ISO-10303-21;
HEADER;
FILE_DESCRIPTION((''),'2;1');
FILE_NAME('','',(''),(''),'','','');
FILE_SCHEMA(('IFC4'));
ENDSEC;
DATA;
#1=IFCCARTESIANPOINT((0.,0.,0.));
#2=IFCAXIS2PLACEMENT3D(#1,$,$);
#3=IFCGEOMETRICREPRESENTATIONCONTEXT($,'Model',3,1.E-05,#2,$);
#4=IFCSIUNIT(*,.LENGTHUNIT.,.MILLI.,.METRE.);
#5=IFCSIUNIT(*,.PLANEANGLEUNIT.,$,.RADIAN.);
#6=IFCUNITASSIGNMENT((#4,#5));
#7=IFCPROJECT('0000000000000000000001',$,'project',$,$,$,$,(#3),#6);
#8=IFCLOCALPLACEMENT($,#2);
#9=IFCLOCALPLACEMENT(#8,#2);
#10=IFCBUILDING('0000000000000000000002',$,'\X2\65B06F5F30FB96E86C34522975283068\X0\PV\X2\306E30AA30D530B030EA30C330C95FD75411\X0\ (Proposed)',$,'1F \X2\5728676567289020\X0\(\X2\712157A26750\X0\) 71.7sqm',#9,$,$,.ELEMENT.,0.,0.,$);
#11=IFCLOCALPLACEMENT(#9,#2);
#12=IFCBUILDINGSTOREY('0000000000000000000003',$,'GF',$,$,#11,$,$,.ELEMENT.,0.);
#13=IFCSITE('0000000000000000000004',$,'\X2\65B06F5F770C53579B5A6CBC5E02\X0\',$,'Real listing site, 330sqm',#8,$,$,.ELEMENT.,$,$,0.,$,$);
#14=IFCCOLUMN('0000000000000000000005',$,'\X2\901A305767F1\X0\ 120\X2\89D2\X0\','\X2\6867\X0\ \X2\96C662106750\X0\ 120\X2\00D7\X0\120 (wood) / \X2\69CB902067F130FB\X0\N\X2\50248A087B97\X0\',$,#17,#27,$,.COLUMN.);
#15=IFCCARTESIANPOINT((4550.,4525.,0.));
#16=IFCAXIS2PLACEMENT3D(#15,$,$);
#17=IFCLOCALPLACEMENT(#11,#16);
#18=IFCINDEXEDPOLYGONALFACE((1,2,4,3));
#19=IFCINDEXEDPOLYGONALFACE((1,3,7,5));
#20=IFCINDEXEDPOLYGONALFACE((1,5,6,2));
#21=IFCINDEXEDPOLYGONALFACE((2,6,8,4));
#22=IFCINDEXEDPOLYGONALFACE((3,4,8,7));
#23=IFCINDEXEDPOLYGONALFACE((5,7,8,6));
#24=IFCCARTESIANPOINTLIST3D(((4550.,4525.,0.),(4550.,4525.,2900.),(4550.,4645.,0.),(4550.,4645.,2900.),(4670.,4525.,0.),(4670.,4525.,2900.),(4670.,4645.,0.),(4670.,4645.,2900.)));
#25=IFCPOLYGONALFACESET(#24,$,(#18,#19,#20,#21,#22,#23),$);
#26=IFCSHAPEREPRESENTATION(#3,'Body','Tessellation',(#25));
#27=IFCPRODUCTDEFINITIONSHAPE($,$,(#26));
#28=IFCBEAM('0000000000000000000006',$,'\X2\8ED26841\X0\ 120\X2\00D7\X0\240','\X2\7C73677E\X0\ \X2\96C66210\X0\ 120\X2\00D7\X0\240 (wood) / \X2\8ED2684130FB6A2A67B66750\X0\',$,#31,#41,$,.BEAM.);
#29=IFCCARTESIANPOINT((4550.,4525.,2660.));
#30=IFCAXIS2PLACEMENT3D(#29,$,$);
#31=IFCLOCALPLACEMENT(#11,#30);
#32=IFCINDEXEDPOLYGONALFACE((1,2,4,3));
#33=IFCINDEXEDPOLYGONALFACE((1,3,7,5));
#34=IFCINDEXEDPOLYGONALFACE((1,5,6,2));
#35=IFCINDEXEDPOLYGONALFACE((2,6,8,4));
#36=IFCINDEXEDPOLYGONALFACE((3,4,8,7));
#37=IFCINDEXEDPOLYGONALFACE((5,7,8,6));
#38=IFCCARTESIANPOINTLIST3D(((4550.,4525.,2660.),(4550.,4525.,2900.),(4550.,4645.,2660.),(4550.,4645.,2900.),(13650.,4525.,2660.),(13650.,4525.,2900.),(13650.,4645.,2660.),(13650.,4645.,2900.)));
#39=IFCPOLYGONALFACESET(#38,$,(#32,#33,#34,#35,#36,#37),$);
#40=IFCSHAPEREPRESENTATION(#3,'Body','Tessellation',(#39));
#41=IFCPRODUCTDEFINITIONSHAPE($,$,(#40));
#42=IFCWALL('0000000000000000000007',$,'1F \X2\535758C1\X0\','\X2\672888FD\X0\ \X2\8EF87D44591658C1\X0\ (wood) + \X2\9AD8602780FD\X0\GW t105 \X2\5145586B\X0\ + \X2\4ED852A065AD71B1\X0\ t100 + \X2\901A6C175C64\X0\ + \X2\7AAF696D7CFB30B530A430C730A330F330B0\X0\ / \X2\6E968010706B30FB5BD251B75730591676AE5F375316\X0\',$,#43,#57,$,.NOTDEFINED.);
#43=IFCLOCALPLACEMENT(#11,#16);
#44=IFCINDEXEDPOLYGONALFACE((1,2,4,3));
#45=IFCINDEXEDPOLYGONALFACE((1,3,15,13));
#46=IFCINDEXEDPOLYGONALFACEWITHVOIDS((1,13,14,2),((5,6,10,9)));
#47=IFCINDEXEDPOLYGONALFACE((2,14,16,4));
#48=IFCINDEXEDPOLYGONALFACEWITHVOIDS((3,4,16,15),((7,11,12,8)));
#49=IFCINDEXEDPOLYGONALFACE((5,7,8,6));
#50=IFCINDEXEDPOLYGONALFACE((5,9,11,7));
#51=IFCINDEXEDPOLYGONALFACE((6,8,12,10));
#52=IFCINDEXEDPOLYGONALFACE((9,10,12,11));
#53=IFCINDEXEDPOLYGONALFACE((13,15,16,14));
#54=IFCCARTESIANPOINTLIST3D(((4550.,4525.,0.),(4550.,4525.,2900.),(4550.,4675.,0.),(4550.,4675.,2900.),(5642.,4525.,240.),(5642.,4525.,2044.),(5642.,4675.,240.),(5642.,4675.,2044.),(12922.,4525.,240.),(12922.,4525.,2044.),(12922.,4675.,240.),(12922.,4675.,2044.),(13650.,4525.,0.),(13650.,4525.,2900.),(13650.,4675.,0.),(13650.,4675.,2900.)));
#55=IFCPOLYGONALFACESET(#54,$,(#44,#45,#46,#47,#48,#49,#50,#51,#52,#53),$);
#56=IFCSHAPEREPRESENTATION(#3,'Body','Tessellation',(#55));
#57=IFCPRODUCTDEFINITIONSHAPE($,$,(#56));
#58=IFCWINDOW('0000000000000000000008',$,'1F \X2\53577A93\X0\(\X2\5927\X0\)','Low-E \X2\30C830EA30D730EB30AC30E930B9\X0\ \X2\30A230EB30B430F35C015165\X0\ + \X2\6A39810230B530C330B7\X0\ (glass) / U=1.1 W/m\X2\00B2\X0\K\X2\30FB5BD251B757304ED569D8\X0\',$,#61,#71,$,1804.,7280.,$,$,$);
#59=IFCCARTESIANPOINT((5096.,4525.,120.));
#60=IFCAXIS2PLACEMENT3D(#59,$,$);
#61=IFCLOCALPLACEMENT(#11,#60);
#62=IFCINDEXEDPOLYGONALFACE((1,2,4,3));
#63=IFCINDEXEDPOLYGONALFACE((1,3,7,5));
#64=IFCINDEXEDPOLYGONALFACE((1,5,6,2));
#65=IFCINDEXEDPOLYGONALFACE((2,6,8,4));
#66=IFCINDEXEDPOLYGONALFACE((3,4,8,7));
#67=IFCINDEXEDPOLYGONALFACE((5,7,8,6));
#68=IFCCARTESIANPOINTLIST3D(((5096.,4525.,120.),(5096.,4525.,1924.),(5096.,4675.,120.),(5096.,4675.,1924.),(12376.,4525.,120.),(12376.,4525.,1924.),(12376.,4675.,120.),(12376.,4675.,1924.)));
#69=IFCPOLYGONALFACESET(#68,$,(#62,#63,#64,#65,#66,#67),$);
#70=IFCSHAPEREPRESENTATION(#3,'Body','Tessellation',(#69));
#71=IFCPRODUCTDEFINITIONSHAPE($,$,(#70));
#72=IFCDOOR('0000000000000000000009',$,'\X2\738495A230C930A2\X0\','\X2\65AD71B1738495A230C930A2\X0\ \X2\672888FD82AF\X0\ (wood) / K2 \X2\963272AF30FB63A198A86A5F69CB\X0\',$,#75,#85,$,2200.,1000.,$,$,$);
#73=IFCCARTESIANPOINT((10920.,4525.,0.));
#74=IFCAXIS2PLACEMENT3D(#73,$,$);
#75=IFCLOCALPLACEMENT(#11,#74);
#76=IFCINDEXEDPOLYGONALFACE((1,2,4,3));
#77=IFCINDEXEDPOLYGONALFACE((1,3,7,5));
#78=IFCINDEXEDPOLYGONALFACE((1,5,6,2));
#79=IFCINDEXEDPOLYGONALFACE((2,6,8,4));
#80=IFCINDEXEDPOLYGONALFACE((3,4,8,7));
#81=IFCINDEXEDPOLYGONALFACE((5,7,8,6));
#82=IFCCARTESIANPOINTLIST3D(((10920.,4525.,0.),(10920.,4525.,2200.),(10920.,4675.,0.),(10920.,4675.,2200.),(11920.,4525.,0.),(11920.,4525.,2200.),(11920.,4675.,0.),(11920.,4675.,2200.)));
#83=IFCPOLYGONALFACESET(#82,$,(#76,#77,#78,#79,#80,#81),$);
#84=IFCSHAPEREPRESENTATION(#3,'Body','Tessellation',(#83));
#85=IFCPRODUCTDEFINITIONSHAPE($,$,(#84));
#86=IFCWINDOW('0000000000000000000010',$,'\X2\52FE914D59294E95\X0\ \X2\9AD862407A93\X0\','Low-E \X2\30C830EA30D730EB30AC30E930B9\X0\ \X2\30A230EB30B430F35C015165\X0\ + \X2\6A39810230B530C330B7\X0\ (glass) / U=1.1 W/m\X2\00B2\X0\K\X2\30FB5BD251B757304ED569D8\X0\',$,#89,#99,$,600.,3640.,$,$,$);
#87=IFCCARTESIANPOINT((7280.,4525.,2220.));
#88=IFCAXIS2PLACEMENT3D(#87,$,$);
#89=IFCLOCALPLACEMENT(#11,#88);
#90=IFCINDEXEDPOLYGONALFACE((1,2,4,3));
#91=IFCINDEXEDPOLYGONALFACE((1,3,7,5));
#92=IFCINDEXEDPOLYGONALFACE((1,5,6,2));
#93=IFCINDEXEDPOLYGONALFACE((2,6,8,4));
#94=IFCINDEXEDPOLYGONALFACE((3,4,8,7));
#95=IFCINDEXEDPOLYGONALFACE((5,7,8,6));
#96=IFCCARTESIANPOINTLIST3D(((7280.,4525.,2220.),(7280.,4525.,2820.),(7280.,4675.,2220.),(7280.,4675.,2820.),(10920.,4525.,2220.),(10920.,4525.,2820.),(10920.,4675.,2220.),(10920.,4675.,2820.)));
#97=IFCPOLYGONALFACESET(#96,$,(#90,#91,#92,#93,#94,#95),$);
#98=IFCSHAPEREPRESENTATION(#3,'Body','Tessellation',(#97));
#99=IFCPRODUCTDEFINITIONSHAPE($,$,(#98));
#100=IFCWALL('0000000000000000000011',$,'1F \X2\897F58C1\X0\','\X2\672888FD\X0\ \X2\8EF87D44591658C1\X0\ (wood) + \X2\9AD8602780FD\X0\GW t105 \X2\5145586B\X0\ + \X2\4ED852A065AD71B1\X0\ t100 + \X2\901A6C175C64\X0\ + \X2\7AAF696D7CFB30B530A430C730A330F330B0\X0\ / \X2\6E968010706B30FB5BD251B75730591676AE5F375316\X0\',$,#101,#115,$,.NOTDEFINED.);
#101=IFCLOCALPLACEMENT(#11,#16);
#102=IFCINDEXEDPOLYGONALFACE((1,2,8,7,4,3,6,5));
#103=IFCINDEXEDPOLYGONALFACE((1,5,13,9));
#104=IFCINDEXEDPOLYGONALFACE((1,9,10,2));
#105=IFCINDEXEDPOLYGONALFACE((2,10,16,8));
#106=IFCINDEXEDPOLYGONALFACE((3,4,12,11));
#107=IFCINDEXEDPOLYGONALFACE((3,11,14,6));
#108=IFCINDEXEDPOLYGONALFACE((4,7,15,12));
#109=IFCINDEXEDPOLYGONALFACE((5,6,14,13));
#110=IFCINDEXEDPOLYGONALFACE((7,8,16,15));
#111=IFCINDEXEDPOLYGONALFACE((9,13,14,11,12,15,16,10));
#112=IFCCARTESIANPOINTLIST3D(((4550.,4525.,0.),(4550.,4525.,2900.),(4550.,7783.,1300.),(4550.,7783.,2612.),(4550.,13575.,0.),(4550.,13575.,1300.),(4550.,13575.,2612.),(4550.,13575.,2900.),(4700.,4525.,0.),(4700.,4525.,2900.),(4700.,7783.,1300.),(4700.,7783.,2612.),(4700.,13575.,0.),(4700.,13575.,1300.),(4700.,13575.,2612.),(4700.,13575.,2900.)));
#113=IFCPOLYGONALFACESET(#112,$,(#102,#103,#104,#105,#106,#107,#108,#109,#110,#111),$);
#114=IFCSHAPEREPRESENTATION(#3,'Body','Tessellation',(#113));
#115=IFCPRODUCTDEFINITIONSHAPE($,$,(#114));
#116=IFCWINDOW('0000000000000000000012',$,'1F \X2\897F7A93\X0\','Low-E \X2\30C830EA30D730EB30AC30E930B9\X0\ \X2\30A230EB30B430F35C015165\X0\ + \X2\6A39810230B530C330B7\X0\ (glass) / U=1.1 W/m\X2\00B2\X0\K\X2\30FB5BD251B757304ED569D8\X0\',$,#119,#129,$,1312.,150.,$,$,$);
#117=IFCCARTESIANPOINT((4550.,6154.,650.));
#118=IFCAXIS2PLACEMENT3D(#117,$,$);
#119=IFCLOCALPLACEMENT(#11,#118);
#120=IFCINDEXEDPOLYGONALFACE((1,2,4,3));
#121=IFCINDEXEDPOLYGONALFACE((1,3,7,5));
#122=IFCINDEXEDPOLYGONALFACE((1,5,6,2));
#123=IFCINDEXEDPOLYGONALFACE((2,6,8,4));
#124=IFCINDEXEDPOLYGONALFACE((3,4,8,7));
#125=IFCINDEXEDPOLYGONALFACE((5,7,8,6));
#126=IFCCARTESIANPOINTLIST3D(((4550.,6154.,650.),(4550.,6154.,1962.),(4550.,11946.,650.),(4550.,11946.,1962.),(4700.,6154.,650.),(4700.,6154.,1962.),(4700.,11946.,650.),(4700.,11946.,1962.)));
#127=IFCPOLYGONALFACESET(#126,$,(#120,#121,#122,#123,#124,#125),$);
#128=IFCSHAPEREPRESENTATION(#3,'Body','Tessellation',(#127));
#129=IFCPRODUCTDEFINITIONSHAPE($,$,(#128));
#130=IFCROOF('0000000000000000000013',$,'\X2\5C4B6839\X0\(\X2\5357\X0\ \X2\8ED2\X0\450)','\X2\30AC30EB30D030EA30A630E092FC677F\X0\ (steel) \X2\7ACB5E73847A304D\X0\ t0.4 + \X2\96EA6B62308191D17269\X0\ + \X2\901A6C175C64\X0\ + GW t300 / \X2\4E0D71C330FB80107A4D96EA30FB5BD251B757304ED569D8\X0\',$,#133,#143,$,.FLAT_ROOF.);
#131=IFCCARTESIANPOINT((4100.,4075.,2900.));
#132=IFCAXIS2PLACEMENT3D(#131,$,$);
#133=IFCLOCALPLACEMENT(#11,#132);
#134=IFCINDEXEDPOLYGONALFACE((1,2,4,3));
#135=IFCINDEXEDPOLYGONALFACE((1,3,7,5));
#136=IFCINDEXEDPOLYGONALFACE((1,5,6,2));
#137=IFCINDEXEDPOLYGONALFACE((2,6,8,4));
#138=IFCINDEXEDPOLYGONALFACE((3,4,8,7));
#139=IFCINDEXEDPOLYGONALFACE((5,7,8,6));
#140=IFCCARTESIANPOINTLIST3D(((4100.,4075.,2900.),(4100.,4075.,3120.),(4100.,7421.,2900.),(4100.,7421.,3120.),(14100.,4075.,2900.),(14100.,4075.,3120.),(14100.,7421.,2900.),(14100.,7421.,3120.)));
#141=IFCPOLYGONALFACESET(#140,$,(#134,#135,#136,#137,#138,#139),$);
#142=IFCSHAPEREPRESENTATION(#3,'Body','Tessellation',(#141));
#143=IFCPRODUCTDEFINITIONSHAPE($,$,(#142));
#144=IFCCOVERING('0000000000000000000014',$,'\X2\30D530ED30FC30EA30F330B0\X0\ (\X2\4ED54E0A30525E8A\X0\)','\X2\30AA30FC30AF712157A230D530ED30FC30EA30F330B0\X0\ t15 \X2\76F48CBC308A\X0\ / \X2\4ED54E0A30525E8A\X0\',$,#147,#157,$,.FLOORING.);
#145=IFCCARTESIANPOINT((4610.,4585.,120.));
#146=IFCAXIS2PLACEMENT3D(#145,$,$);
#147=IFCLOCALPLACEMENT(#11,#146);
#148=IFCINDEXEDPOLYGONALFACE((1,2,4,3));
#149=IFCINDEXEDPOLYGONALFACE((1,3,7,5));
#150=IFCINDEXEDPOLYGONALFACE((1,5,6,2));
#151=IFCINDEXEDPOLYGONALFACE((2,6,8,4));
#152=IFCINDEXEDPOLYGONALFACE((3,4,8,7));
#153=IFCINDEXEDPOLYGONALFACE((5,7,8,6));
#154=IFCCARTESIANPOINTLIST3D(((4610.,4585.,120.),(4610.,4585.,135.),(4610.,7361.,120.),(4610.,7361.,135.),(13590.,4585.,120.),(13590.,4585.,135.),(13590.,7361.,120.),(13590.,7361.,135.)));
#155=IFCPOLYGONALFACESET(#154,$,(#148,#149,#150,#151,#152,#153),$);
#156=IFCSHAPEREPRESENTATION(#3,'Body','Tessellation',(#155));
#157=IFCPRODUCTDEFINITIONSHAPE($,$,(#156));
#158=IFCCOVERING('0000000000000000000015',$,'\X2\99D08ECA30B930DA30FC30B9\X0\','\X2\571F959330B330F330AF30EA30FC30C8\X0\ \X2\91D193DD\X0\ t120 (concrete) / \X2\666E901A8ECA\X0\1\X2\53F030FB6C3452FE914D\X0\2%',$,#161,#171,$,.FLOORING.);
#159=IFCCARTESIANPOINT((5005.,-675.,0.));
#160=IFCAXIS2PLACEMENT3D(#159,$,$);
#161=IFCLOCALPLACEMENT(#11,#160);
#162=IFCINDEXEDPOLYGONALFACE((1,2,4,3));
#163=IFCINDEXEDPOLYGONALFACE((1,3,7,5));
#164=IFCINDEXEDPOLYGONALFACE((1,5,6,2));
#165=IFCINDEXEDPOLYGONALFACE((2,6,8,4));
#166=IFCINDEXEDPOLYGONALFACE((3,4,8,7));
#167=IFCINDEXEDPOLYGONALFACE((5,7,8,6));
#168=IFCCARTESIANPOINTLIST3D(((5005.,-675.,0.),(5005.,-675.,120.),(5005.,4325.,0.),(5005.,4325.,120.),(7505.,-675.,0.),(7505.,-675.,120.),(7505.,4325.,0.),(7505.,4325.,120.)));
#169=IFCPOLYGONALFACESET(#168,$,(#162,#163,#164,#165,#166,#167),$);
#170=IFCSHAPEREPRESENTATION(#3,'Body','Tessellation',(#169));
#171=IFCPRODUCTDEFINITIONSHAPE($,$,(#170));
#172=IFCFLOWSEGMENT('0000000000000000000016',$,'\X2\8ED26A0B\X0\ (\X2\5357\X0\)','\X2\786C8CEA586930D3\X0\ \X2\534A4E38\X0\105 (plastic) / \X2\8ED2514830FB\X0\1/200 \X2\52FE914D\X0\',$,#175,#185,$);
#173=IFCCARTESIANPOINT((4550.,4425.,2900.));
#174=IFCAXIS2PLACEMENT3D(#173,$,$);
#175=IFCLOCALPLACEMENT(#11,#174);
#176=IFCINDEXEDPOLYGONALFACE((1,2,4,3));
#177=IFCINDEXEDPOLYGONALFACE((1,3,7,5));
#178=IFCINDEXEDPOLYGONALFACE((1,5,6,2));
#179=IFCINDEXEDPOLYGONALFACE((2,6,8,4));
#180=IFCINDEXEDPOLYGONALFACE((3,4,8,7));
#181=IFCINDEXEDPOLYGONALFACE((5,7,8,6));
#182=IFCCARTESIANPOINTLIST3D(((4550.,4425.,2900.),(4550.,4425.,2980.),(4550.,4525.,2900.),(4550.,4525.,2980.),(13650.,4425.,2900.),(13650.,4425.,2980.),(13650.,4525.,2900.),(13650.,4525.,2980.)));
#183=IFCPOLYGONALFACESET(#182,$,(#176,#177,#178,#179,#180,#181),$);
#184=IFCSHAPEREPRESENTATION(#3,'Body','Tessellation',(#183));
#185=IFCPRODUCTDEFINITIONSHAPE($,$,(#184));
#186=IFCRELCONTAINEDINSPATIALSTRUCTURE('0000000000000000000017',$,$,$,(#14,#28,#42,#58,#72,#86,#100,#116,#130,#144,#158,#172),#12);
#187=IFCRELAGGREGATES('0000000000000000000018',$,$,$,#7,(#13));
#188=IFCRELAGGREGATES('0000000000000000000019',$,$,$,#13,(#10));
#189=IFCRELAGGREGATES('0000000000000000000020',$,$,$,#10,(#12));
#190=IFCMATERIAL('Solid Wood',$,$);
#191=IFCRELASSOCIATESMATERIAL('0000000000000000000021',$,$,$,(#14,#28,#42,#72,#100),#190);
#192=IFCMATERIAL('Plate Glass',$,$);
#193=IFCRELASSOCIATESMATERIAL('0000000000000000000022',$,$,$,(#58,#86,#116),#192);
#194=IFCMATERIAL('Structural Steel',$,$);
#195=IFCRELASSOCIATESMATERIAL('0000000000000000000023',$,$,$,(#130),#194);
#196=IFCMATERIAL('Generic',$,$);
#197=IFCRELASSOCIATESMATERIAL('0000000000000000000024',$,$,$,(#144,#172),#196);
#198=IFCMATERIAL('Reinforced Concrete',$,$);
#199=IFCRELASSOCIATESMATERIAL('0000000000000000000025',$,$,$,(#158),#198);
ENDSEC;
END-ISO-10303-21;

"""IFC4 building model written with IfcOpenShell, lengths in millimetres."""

from ifc_helpers import new_model, si_unit, frame, frame_2d, origin, place, context, project, spatial, rectangle, extrude, material, element, fill, save


model = new_model("IFC4")

# Units and contexts
model_context = context("Model", 3, precision=1e-05, world=origin())
ifc_project = project(units=[si_unit("LENGTHUNIT", "METRE", prefix="MILLI"), si_unit("PLANEANGLEUNIT", "RADIAN")], contexts=[model_context])

# Site, building, storey
site_placement = place(None, origin())
site = spatial("IfcSite", under=ifc_project, at=site_placement, Name="新潟県南魚沼市", ObjectType="Real listing site, 330sqm", CompositionType="ELEMENT", RefElevation=0.0)
building_placement = place(site_placement, origin())
building = spatial("IfcBuilding", under=site, at=building_placement, Name="新潟・雨水利用とPVのオフグリッド志向 (Proposed)", ObjectType="1F 在来木造(無垢材) 71.7sqm", CompositionType="ELEMENT", ElevationOfRefHeight=0.0, ElevationOfTerrain=0.0)
storey_placement = place(building_placement, origin())
storey = spatial("IfcBuildingStorey", under=building, at=storey_placement, Name="GF", CompositionType="ELEMENT", Elevation=0.0)

# Column
ifc_material_1 = material(Name="Solid Wood")
column_1_placement = place(storey_placement, frame((4550.0, 4525.0, 0.0)))
element("IfcColumn", 1, at=column_1_placement, inside=storey, material=ifc_material_1, Name="通し柱 120角", Description="桧 集成材 120×120 (wood) / 構造柱・N値計算", PredefinedType="COLUMN", context=model_context, shape_type="SweptSolid", body=[
    extrude(rectangle(XDim=120.0, YDim=120.0, at=frame_2d((60.0, 60.0))), frame((4550.0, 4525.0, 0.0)), (0.0, 0.0, 1.0), 2900.0),
])

# Beam
beam_1_placement = place(storey_placement, frame((4550.0, 4525.0, 2660.0)))
element("IfcBeam", 2, at=beam_1_placement, inside=storey, material=ifc_material_1, Name="軒桁 120×240", Description="米松 集成 120×240 (wood) / 軒桁・横架材", PredefinedType="BEAM", context=model_context, shape_type="SweptSolid", body=[
    extrude(rectangle(XDim=9100.0, YDim=120.0, at=frame_2d((4550.0, 60.0))), frame((4550.0, 4525.0, 2660.0)), (0.0, 0.0, 1.0), 240.0),
])

# Shared definitions
ifc_material_2 = material(Name="Reinforced Concrete")

# Wall, openings, windows, door
wall_1_placement = place(storey_placement, frame((4550.0, 4525.0, 0.0)))
wall_1 = element("IfcWall", 3, at=wall_1_placement, inside=storey, material=ifc_material_1, Name="1F 南壁", Description="木製 軸組外壁 (wood) + 高性能GW t105 充填 + 付加断熱 t100 + 通気層 + 窯業系サイディング / 準耐火・寒冷地外皮強化", PredefinedType="NOTDEFINED", context=model_context, shape_type="SweptSolid", body=[
    extrude(rectangle(XDim=9100.0, YDim=150.0, at=frame_2d((4550.0, 75.0))), frame((4550.0, 4525.0, 0.0)), (0.0, 0.0, 1.0), 2900.0),
])
opening_1_placement = place(storey_placement, frame((5096.0, 4525.0, 120.0)))
opening_1 = element("IfcOpeningElement", 4, at=opening_1_placement, cuts=wall_1, PredefinedType="NOTDEFINED", context=model_context, shape_type="SweptSolid", body=[
    extrude(rectangle(XDim=7280.0, YDim=150.0, at=frame_2d((3640.0, 75.0))), frame((5096.0, 4525.0, 120.0)), (0.0, 0.0, 1.0), 1804.0),
])
opening_2_placement = place(storey_placement, frame((10920.0, 4525.0, 0.0)))
opening_2 = element("IfcOpeningElement", 5, at=opening_2_placement, cuts=wall_1, PredefinedType="NOTDEFINED", context=model_context, shape_type="SweptSolid", body=[
    extrude(rectangle(XDim=1000.0, YDim=150.0, at=frame_2d((500.0, 75.0))), frame((10920.0, 4525.0, 0.0)), (0.0, 0.0, 1.0), 2200.0),
])
opening_3_placement = place(storey_placement, frame((7280.0, 4525.0, 2220.0)))
opening_3 = element("IfcOpeningElement", 6, at=opening_3_placement, cuts=wall_1, PredefinedType="NOTDEFINED", context=model_context, shape_type="SweptSolid", body=[
    extrude(rectangle(XDim=3640.0, YDim=150.0, at=frame_2d((1820.0, 75.0))), frame((7280.0, 4525.0, 2220.0)), (0.0, 0.0, 1.0), 600.0),
])
ifc_material_3 = material(Name="Plate Glass")
window_1_placement = place(storey_placement, frame((5096.0, 4525.0, 120.0)))
window_1 = element("IfcWindow", 7, at=window_1_placement, inside=storey, material=ifc_material_3, Name="1F 南窓(大)", Description="Low-E トリプルガラス アルゴン封入 + 樹脂サッシ (glass) / U=1.1 W/m²K・寒冷地仕様", OverallHeight=1804.0, OverallWidth=7280.0, context=model_context, shape_type="SweptSolid", body=[
    extrude(rectangle(XDim=7280.0, YDim=150.0, at=frame_2d((3640.0, 75.0))), frame((5096.0, 4525.0, 120.0)), (0.0, 0.0, 1.0), 1804.0),
])
fill(opening_1, window_1)
door_placement = place(storey_placement, frame((10920.0, 4525.0, 0.0)))
door = element("IfcDoor", 8, at=door_placement, inside=storey, material=ifc_material_1, Name="玄関ドア", Description="断熱玄関ドア 木製芯 (wood) / K2 防犯・採風機構", OverallHeight=2200.0, OverallWidth=1000.0, context=model_context, shape_type="SweptSolid", body=[
    extrude(rectangle(XDim=1000.0, YDim=150.0, at=frame_2d((500.0, 75.0))), frame((10920.0, 4525.0, 0.0)), (0.0, 0.0, 1.0), 2200.0),
])
fill(opening_2, door)
window_2_placement = place(storey_placement, frame((7280.0, 4525.0, 2220.0)))
window_2 = element("IfcWindow", 9, at=window_2_placement, inside=storey, material=ifc_material_3, Name="勾配天井 高所窓", Description="Low-E トリプルガラス アルゴン封入 + 樹脂サッシ (glass) / U=1.1 W/m²K・寒冷地仕様", OverallHeight=600.0, OverallWidth=3640.0, context=model_context, shape_type="SweptSolid", body=[
    extrude(rectangle(XDim=3640.0, YDim=150.0, at=frame_2d((1820.0, 75.0))), frame((7280.0, 4525.0, 2220.0)), (0.0, 0.0, 1.0), 600.0),
])
fill(opening_3, window_2)

# Wall, opening, window
wall_2_placement = place(storey_placement, frame((4550.0, 4525.0, 0.0)))
wall_2 = element("IfcWall", 10, at=wall_2_placement, inside=storey, material=ifc_material_1, Name="1F 西壁", Description="木製 軸組外壁 (wood) + 高性能GW t105 充填 + 付加断熱 t100 + 通気層 + 窯業系サイディング / 準耐火・寒冷地外皮強化", PredefinedType="NOTDEFINED", context=model_context, shape_type="SweptSolid", body=[
    extrude(rectangle(XDim=150.0, YDim=9050.0, at=frame_2d((75.0, 4525.0))), frame((4550.0, 4525.0, 0.0)), (0.0, 0.0, 1.0), 2900.0),
])
opening_4_placement = place(storey_placement, frame((4550.0, 6154.0, 650.0)))
opening_4 = element("IfcOpeningElement", 11, at=opening_4_placement, cuts=wall_2, PredefinedType="NOTDEFINED", context=model_context, shape_type="SweptSolid", body=[
    extrude(rectangle(XDim=150.0, YDim=5792.0, at=frame_2d((75.0, 2896.0))), frame((4550.0, 6154.0, 650.0)), (0.0, 0.0, 1.0), 1312.0),
])
window_3_placement = place(storey_placement, frame((4550.0, 6154.0, 650.0)))
window_3 = element("IfcWindow", 12, at=window_3_placement, inside=storey, material=ifc_material_3, Name="1F 西窓", Description="Low-E トリプルガラス アルゴン封入 + 樹脂サッシ (glass) / U=1.1 W/m²K・寒冷地仕様", OverallHeight=1312.0, OverallWidth=150.0, context=model_context, shape_type="SweptSolid", body=[
    extrude(rectangle(XDim=150.0, YDim=5792.0, at=frame_2d((75.0, 2896.0))), frame((4550.0, 6154.0, 650.0)), (0.0, 0.0, 1.0), 1312.0),
])
fill(opening_4, window_3)

# Roof
ifc_material_4 = material(Name="Structural Steel")
roof_placement = place(storey_placement, frame((4100.0, 4075.0, 2900.0)))
element("IfcRoof", 13, at=roof_placement, inside=storey, material=ifc_material_4, Name="屋根(南 軒450)", Description="ガルバリウム鋼板 (steel) 立平葺き t0.4 + 雪止め金物 + 通気層 + GW t300 / 不燃・耐積雪・寒冷地仕様", PredefinedType="FLAT_ROOF", context=model_context, shape_type="SweptSolid", body=[
    extrude(rectangle(XDim=10000.0, YDim=3346.0, at=frame_2d((5000.0, 1673.0))), frame((4100.0, 4075.0, 2900.0)), (0.0, 0.0, 1.0), 220.0),
])

# Coverings
ifc_material_5 = material(Name="Generic")
covering_1_placement = place(storey_placement, frame((4610.0, 4585.0, 120.0)))
element("IfcCovering", 14, at=covering_1_placement, inside=storey, material=ifc_material_5, Name="フローリング (仕上げ床)", Description="オーク無垢フローリング t15 直貼り / 仕上げ床", PredefinedType="FLOORING", context=model_context, shape_type="SweptSolid", body=[
    extrude(rectangle(XDim=8980.0, YDim=2776.0, at=frame_2d((4490.0, 1388.0))), frame((4610.0, 4585.0, 120.0)), (0.0, 0.0, 1.0), 15.0),
])
covering_2_placement = place(storey_placement, frame((5005.0, -675.0, 0.0)))
element("IfcCovering", 15, at=covering_2_placement, inside=storey, material=ifc_material_2, Name="駐車スペース", Description="土間コンクリート 金鏝 t120 (concrete) / 普通車1台・水勾配2%", PredefinedType="FLOORING", context=model_context, shape_type="SweptSolid", body=[
    extrude(rectangle(XDim=2500.0, YDim=5000.0, at=frame_2d((1250.0, 2500.0))), frame((5005.0, -675.0, 0.0)), (0.0, 0.0, 1.0), 120.0),
])

# Flow segment
flow_segment_1_placement = place(storey_placement, frame((4550.0, 4425.0, 2900.0)))
element("IfcFlowSegment", 16, at=flow_segment_1_placement, inside=storey, material=ifc_material_5, Name="軒樋 (南)", Description="硬質塩ビ 半丸105 (plastic) / 軒先・1/200 勾配", context=model_context, shape_type="SweptSolid", body=[
    extrude(rectangle(XDim=9100.0, YDim=100.0, at=frame_2d((4550.0, 50.0))), frame((4550.0, 4425.0, 2900.0)), (0.0, 0.0, 1.0), 80.0),
])

save(model, "model.ifc")
